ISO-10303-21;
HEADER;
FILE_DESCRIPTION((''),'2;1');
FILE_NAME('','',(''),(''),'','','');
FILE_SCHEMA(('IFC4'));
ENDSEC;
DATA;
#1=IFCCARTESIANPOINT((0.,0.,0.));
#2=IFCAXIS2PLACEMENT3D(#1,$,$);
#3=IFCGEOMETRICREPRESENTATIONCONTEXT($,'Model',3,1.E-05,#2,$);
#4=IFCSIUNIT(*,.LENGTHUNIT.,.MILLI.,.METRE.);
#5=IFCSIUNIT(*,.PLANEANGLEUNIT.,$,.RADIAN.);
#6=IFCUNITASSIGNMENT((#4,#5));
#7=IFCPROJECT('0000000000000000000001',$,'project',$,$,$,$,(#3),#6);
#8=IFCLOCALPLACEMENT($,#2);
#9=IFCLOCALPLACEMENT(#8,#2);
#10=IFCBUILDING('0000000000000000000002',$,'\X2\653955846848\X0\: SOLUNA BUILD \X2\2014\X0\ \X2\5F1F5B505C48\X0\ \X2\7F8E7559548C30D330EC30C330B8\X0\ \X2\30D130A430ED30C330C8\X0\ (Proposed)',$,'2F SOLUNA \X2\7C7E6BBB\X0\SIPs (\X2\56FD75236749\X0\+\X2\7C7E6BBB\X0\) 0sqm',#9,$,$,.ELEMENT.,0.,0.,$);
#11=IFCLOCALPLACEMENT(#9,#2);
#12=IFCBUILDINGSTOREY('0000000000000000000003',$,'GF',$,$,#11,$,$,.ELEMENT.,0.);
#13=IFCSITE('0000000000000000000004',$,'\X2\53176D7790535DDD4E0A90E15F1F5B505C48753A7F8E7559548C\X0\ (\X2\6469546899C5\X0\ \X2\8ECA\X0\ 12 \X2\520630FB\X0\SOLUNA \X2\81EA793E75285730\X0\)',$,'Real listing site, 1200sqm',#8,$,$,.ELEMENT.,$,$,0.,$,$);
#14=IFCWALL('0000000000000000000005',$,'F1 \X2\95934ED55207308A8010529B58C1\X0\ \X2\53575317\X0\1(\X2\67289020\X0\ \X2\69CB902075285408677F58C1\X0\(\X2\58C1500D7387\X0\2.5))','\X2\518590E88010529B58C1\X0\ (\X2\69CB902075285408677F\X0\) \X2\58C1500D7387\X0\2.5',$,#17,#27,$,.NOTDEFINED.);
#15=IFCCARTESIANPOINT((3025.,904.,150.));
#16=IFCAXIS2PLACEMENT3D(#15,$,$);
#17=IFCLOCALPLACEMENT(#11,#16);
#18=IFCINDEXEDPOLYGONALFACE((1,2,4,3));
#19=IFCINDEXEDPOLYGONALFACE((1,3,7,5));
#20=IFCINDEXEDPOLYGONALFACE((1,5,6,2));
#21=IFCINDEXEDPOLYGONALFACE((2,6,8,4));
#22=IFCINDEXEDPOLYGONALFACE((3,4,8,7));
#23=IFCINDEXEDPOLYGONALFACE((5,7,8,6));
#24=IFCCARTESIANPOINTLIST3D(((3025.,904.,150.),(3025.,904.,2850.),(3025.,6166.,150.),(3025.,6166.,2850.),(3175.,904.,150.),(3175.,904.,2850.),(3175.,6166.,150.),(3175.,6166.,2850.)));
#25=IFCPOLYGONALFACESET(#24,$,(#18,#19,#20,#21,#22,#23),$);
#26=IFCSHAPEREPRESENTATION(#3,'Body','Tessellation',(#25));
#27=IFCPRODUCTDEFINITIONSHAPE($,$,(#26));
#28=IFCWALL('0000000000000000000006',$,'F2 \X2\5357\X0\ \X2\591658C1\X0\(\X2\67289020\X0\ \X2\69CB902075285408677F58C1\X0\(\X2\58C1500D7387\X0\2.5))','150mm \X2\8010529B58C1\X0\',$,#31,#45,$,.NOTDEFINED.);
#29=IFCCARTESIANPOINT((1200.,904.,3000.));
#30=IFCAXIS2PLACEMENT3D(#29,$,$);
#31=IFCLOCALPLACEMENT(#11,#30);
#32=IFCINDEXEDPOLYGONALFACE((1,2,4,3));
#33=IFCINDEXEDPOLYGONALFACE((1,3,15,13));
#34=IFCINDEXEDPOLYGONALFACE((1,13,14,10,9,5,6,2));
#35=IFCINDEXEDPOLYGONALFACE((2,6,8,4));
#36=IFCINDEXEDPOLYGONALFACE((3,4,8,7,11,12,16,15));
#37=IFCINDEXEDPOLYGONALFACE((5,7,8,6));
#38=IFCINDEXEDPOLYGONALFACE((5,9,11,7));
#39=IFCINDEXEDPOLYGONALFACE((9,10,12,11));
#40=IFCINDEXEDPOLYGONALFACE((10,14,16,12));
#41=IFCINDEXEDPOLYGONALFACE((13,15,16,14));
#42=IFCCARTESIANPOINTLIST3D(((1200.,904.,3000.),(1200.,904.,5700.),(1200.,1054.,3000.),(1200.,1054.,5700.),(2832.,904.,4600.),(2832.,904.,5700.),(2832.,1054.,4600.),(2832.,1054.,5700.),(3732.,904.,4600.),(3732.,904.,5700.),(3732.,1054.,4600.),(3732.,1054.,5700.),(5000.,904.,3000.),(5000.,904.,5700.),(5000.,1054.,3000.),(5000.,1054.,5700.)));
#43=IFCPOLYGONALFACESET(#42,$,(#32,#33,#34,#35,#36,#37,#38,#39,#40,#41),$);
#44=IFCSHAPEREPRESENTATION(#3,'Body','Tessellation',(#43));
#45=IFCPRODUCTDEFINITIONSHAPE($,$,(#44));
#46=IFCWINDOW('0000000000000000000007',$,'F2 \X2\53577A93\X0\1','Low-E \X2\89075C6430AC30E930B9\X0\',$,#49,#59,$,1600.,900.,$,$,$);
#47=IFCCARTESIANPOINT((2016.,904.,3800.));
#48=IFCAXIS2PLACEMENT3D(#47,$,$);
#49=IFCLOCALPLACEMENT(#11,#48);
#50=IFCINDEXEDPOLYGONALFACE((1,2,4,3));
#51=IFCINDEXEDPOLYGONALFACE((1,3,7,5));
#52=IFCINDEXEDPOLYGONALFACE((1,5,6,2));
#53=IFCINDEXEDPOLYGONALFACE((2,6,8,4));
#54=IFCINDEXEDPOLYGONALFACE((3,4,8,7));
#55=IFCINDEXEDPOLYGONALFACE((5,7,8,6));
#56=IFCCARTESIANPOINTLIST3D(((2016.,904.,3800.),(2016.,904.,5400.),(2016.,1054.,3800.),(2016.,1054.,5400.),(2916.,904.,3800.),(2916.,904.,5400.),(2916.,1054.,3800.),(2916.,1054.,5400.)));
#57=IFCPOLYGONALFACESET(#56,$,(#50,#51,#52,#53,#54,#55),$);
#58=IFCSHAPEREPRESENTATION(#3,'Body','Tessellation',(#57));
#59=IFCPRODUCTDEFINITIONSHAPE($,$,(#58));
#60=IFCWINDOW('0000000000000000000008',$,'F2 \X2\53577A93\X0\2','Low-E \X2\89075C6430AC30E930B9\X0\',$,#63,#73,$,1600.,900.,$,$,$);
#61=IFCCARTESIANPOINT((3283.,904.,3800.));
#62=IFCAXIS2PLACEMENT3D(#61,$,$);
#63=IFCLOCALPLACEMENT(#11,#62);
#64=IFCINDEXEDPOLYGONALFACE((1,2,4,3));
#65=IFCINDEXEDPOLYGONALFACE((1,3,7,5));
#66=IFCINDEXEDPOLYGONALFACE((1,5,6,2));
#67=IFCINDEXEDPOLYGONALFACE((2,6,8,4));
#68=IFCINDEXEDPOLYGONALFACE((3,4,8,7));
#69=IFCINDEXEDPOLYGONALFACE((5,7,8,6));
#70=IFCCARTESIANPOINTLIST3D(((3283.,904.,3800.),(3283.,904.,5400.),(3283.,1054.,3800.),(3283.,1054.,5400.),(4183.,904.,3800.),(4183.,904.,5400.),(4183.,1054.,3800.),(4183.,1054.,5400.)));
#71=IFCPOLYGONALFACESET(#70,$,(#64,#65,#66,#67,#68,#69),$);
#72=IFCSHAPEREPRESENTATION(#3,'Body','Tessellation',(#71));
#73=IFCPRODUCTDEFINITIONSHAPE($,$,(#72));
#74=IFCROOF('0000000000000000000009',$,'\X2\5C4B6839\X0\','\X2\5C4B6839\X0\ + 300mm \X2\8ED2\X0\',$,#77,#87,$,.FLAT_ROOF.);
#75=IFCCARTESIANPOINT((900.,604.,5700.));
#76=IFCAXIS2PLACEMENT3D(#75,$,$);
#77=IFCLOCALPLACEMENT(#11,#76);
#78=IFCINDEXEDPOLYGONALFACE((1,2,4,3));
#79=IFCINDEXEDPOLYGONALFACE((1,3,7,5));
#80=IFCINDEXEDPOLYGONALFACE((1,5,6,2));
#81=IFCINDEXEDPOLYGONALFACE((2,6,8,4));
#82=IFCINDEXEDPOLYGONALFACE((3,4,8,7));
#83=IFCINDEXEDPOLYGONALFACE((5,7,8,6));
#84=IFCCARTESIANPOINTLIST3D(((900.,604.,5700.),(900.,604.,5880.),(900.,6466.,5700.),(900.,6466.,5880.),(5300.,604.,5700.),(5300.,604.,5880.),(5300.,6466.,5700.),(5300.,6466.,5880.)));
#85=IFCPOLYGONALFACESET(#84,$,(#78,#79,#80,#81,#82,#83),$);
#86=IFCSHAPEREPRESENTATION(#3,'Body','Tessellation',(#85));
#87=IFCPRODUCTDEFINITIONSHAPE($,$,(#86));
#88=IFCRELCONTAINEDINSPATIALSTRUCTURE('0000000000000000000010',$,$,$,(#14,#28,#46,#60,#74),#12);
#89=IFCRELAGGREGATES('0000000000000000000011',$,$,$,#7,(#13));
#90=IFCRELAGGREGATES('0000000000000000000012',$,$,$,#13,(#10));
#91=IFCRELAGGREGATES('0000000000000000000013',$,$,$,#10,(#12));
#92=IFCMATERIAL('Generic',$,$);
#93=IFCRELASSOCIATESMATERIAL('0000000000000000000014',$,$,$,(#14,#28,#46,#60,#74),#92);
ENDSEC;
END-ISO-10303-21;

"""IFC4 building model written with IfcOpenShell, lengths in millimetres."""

from ifc_helpers import new_model, si_unit, frame, frame_2d, origin, place, context, project, spatial, rectangle, extrude, material, element, fill, save


model = new_model("IFC4")

# Units and contexts
model_context = context("Model", 3, precision=1e-05, world=origin())
ifc_project = project(units=[si_unit("LENGTHUNIT", "METRE", prefix="MILLI"), si_unit("PLANEANGLEUNIT", "RADIAN")], contexts=[model_context])

# Site, building, storey
site_placement = place(None, origin())
site = spatial("IfcSite", under=ifc_project, at=site_placement, Name="北海道川上郡弟子屈町美留和 (摩周駅 車 12 分・SOLUNA 自社用地)", ObjectType="Real listing site, 1200sqm", CompositionType="ELEMENT", RefElevation=0.0)
building_placement = place(site_placement, origin())
building = spatial("IfcBuilding", under=site, at=building_placement, Name="改善案: SOLUNA BUILD — 弟子屈 美留和ビレッジ パイロット (Proposed)", ObjectType="2F SOLUNA 籾殻SIPs (国産杉+籾殻) 0sqm", CompositionType="ELEMENT", ElevationOfRefHeight=0.0, ElevationOfTerrain=0.0)
storey_placement = place(building_placement, origin())
storey = spatial("IfcBuildingStorey", under=building, at=storey_placement, Name="GF", CompositionType="ELEMENT", Elevation=0.0)

# Shared definitions
ifc_material_1 = material(Name="Generic")

# Wall
wall_1_placement = place(storey_placement, frame((3025.0, 904.0, 150.0)))
element("IfcWall", 1, at=wall_1_placement, inside=storey, material=ifc_material_1, Name="F1 間仕切り耐力壁 南北1(木造 構造用合板壁(壁倍率2.5))", Description="内部耐力壁 (構造用合板) 壁倍率2.5", PredefinedType="NOTDEFINED", context=model_context, shape_type="SweptSolid", body=[
    extrude(rectangle(XDim=150.0, YDim=5262.0, at=frame_2d((75.0, 2631.0))), frame((3025.0, 904.0, 150.0)), (0.0, 0.0, 1.0), 2700.0),
])

# Wall, openings, windows
wall_2_placement = place(storey_placement, frame((1200.0, 904.0, 3000.0)))
wall_2 = element("IfcWall", 2, at=wall_2_placement, inside=storey, material=ifc_material_1, Name="F2 南 外壁(木造 構造用合板壁(壁倍率2.5))", Description="150mm 耐力壁", PredefinedType="NOTDEFINED", context=model_context, shape_type="SweptSolid", body=[
    extrude(rectangle(XDim=3800.0, YDim=150.0, at=frame_2d((1900.0, 75.0))), frame((1200.0, 904.0, 3000.0)), (0.0, 0.0, 1.0), 2700.0),
])
opening_1_placement = place(storey_placement, frame((2016.0, 904.0, 3800.0)))
opening_1 = element("IfcOpeningElement", 3, at=opening_1_placement, cuts=wall_2, PredefinedType="NOTDEFINED", context=model_context, shape_type="SweptSolid", body=[
    extrude(rectangle(XDim=900.0, YDim=150.0, at=frame_2d((450.0, 75.0))), frame((2016.0, 904.0, 3800.0)), (0.0, 0.0, 1.0), 1600.0),
])
opening_2_placement = place(storey_placement, frame((3283.0, 904.0, 3800.0)))
opening_2 = element("IfcOpeningElement", 4, at=opening_2_placement, cuts=wall_2, PredefinedType="NOTDEFINED", context=model_context, shape_type="SweptSolid", body=[
    extrude(rectangle(XDim=900.0, YDim=150.0, at=frame_2d((450.0, 75.0))), frame((3283.0, 904.0, 3800.0)), (0.0, 0.0, 1.0), 1600.0),
])
window_1_placement = place(storey_placement, frame((2016.0, 904.0, 3800.0)))
window_1 = element("IfcWindow", 5, at=window_1_placement, inside=storey, material=ifc_material_1, Name="F2 南窓1", Description="Low-E 複層ガラス", OverallHeight=1600.0, OverallWidth=900.0, context=model_context, shape_type="SweptSolid", body=[
    extrude(rectangle(XDim=900.0, YDim=150.0, at=frame_2d((450.0, 75.0))), frame((2016.0, 904.0, 3800.0)), (0.0, 0.0, 1.0), 1600.0),
])
fill(opening_1, window_1)
window_2_placement = place(storey_placement, frame((3283.0, 904.0, 3800.0)))
window_2 = element("IfcWindow", 6, at=window_2_placement, inside=storey, material=ifc_material_1, Name="F2 南窓2", Description="Low-E 複層ガラス", OverallHeight=1600.0, OverallWidth=900.0, context=model_context, shape_type="SweptSolid", body=[
    extrude(rectangle(XDim=900.0, YDim=150.0, at=frame_2d((450.0, 75.0))), frame((3283.0, 904.0, 3800.0)), (0.0, 0.0, 1.0), 1600.0),
])
fill(opening_2, window_2)

# Roof
roof_placement = place(storey_placement, frame((900.0, 604.0, 5700.0)))
element("IfcRoof", 7, at=roof_placement, inside=storey, material=ifc_material_1, Name="屋根", Description="屋根 + 300mm 軒", PredefinedType="FLAT_ROOF", context=model_context, shape_type="SweptSolid", body=[
    extrude(rectangle(XDim=4400.0, YDim=5862.0, at=frame_2d((2200.0, 2931.0))), frame((900.0, 604.0, 5700.0)), (0.0, 0.0, 1.0), 180.0),
])

save(model, "model.ifc")
